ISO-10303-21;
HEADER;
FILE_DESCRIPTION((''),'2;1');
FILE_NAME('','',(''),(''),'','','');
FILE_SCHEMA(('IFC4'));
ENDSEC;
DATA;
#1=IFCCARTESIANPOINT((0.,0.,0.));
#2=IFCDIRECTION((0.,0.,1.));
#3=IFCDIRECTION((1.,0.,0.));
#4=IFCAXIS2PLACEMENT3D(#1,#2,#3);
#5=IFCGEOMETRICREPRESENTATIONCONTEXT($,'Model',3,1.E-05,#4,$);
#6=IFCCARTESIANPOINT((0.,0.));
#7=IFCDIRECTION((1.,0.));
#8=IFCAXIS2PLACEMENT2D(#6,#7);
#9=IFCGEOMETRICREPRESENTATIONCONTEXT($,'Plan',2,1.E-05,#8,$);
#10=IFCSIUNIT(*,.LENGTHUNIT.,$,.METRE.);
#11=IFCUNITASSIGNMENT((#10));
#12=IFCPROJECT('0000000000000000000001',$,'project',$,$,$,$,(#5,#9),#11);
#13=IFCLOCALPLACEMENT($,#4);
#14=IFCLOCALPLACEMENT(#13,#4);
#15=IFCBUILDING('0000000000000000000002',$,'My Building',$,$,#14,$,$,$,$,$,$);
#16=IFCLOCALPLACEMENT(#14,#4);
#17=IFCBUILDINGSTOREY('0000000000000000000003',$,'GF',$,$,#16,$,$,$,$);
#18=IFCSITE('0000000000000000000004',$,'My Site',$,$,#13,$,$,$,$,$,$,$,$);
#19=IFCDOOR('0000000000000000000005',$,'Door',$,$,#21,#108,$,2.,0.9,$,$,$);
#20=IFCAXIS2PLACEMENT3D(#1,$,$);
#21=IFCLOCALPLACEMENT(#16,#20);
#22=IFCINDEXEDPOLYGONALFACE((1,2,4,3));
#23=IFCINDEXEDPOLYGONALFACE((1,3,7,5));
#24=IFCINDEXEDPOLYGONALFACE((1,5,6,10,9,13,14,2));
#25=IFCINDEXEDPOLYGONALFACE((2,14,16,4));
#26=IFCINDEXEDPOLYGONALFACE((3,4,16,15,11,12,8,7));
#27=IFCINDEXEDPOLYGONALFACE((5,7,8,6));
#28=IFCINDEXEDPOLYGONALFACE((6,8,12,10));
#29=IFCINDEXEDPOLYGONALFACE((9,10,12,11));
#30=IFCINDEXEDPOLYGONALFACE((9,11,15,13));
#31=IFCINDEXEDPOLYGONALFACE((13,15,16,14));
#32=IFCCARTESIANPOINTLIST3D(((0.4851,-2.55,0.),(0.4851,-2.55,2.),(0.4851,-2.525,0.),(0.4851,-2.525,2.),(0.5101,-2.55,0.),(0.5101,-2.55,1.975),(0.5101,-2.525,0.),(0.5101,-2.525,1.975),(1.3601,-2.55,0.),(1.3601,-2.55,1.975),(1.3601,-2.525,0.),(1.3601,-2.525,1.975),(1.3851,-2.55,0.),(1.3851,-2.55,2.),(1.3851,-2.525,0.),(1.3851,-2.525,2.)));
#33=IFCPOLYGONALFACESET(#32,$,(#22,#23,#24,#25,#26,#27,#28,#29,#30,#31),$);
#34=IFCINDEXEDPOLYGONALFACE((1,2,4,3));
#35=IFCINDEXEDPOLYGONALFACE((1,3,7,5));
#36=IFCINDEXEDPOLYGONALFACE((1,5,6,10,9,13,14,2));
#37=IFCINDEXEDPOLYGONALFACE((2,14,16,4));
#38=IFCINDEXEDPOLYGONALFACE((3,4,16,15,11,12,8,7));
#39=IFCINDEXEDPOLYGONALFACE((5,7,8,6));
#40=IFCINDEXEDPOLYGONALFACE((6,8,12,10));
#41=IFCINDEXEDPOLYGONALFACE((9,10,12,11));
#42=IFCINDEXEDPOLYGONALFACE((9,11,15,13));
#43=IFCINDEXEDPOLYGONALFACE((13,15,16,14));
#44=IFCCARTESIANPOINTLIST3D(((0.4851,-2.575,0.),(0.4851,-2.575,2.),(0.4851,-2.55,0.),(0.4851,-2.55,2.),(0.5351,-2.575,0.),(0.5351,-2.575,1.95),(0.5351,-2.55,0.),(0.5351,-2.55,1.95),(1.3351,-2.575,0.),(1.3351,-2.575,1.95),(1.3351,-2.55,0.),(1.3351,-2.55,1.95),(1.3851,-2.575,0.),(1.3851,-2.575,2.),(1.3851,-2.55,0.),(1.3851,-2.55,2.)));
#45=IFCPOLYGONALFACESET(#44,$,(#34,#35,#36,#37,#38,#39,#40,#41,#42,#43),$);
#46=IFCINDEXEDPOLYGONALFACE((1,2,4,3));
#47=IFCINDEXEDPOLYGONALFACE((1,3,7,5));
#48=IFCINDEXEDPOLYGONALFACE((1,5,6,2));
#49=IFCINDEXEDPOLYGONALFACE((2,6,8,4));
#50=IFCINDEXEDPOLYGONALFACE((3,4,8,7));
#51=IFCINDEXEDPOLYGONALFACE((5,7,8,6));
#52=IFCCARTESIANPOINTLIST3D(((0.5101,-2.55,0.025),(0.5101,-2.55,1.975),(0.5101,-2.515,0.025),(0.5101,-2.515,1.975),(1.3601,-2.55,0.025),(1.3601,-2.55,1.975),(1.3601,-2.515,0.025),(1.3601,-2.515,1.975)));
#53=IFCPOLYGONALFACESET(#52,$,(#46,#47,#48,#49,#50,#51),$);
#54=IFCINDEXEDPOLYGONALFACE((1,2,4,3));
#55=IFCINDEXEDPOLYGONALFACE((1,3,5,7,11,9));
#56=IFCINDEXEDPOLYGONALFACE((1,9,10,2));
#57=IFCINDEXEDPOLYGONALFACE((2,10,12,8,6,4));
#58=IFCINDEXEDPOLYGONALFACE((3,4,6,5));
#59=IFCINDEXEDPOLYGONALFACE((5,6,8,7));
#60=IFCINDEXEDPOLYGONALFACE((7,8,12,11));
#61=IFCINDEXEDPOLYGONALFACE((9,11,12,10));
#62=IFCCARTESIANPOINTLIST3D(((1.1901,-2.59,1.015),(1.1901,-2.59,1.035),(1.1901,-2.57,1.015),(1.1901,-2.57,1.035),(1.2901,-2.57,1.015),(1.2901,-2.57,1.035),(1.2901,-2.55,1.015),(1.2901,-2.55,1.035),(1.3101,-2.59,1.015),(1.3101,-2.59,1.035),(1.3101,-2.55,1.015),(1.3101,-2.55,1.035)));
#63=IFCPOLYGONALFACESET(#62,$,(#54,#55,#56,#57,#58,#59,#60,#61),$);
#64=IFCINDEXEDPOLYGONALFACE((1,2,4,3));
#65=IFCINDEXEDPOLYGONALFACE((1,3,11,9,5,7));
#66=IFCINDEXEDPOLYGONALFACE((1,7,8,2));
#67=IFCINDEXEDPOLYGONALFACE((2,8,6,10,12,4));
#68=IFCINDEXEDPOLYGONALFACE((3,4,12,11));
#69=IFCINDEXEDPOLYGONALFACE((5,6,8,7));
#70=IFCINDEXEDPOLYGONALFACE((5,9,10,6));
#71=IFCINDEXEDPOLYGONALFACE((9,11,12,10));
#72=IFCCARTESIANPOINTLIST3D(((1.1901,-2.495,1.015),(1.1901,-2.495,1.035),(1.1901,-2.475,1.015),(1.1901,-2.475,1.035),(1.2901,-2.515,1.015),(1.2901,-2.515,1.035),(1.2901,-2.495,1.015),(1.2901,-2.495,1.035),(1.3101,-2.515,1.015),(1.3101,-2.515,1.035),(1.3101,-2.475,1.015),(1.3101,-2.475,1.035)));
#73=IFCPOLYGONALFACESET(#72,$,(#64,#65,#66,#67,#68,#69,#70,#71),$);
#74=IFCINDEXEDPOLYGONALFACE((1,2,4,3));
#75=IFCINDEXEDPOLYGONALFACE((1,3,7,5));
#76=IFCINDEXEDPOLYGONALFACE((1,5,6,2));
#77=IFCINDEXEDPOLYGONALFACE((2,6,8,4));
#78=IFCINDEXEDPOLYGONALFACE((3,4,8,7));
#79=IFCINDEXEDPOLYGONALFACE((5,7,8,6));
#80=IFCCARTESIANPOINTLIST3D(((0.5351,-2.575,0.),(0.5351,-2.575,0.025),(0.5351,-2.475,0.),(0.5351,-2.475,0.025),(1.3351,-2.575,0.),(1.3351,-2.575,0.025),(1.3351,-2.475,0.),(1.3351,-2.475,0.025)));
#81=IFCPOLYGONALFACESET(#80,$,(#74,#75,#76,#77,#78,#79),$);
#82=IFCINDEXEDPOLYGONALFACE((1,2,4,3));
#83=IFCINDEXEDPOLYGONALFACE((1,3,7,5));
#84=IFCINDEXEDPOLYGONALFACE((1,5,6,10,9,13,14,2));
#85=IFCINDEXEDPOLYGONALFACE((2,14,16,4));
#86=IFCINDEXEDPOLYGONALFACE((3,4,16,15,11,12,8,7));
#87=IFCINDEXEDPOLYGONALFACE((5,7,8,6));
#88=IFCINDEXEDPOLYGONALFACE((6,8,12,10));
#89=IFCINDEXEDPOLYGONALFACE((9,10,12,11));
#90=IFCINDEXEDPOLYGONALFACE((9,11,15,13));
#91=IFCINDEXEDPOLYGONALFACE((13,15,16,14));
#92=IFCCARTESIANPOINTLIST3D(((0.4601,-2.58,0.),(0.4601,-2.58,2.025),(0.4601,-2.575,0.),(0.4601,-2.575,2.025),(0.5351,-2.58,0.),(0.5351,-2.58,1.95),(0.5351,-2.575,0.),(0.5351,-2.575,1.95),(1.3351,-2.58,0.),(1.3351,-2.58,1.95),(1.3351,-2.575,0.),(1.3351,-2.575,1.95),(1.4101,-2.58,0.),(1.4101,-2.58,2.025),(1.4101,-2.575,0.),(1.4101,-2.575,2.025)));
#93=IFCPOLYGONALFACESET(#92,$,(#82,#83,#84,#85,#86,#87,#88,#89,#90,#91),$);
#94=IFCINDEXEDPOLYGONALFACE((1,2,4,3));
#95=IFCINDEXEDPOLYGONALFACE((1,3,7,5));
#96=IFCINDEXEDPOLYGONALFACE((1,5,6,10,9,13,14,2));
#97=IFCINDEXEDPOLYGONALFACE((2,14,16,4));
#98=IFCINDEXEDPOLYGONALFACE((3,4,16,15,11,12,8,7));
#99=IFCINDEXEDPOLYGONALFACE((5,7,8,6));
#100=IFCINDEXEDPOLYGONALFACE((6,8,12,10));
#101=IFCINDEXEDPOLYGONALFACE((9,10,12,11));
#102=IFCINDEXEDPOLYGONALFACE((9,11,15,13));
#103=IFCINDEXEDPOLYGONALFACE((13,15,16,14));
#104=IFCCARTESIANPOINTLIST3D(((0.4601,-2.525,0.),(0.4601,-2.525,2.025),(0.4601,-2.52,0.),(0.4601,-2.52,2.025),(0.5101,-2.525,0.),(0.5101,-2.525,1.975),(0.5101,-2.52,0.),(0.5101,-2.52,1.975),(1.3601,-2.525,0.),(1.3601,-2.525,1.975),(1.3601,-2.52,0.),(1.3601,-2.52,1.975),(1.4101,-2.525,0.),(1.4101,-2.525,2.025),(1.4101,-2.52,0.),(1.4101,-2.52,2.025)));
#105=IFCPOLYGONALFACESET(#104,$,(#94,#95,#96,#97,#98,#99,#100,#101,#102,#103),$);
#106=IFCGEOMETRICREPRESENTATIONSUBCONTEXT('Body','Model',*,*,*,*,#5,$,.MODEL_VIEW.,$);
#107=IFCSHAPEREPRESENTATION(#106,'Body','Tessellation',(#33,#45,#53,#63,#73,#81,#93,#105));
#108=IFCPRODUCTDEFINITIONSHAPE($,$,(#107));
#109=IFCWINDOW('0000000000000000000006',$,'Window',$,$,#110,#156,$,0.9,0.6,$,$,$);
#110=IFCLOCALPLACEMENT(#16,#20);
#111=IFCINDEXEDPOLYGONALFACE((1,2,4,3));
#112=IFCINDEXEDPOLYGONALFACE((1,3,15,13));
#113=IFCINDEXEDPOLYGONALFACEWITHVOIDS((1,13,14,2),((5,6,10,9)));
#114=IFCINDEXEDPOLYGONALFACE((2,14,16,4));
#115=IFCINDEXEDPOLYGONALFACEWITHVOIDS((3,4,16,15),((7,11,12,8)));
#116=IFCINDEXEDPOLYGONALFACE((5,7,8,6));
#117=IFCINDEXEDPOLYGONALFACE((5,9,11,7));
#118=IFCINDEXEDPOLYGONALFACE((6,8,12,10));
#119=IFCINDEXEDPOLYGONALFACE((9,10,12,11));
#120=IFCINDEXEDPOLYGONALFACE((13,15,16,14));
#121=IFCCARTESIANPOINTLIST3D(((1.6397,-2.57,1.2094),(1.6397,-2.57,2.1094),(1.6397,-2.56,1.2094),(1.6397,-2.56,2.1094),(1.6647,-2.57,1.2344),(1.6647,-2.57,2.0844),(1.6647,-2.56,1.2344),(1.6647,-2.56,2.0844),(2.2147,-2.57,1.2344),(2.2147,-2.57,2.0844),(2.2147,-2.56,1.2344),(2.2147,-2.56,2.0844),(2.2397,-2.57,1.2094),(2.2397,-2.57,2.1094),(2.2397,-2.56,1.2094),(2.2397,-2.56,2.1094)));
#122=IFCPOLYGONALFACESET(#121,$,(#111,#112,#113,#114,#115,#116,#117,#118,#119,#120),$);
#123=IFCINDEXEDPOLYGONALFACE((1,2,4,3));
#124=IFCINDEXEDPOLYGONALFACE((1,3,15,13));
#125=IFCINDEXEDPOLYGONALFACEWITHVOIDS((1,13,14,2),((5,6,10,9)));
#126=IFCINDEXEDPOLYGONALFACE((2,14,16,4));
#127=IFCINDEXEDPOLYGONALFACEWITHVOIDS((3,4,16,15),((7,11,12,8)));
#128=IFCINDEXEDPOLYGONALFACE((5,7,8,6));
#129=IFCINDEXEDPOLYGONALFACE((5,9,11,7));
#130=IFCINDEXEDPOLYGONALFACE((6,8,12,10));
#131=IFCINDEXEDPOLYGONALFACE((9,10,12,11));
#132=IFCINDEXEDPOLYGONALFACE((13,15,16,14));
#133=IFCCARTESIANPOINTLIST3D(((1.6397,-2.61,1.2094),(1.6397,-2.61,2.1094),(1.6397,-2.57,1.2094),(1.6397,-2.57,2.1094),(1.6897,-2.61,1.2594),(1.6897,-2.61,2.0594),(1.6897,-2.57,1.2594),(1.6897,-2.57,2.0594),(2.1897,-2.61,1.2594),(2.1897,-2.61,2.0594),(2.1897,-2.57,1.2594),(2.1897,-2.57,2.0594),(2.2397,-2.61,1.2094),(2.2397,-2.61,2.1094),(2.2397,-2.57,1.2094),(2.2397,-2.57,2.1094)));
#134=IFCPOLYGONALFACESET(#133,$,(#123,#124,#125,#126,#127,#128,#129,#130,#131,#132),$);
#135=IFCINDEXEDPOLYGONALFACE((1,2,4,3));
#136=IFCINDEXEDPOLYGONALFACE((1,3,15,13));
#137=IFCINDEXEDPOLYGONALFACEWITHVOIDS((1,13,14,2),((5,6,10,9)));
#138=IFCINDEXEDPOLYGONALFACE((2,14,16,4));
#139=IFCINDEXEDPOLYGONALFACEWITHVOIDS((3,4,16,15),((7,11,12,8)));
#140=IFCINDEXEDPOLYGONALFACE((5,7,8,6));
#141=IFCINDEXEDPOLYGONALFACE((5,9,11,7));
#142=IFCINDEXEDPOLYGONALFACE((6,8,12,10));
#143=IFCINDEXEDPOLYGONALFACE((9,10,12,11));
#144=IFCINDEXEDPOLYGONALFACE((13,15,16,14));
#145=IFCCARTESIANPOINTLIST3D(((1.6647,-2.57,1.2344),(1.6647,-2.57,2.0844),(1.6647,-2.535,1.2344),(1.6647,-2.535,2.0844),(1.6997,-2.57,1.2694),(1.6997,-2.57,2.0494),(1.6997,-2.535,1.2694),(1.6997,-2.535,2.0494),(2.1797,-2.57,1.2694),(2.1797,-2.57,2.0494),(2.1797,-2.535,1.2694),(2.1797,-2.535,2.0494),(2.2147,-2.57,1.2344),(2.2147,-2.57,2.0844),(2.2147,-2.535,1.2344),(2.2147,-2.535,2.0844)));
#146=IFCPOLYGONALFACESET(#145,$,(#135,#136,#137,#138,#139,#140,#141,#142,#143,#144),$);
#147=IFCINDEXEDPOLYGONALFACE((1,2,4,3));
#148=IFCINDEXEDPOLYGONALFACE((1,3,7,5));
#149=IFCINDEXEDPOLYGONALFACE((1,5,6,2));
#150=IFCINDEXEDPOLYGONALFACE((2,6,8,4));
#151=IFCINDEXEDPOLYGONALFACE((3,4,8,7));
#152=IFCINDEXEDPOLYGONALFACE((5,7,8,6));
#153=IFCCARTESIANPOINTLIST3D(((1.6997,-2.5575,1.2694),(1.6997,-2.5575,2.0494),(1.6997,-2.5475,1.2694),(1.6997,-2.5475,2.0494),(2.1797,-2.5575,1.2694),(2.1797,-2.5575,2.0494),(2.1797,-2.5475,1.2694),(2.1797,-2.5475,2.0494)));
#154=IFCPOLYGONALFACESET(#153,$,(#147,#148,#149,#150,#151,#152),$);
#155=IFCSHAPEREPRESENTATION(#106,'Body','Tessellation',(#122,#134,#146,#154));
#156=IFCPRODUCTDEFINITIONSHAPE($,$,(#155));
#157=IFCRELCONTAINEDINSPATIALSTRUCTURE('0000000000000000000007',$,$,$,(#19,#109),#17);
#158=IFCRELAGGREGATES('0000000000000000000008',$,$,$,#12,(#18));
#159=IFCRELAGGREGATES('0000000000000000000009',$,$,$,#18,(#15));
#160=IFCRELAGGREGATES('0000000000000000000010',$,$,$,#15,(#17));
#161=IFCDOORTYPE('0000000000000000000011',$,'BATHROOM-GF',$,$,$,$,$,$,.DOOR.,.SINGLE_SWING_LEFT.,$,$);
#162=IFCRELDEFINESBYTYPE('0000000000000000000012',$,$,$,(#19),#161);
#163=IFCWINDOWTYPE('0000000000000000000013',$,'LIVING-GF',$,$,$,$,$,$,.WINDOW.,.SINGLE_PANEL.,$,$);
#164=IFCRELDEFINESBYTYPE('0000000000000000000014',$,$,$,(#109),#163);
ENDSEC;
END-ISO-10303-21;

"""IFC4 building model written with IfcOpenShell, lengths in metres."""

from ifc_helpers import new_model, entity, si_unit, frame, origin_with_axes, origin_2d_with_axis, place, context, subcontext, project, spatial, line, indexed_curve, outline, extrude, shape, source, transform, mapped, type_object, type_shapes, element, save


model = new_model("IFC4")

# Units and contexts
model_context = context("Model", 3, precision=1e-05, world=origin_with_axes())
plan_context = context("Plan", 2, precision=1e-05, world=origin_2d_with_axis())
body_context_1 = subcontext(model_context, "Body", "Model", "MODEL_VIEW")
body_context_2 = subcontext(plan_context, "Body", "Plan", "PLAN_VIEW")
ifc_project = project(units=[si_unit("LENGTHUNIT", "METRE")], contexts=[model_context, plan_context])

# Site, building, storey
site_placement = place(None, origin_with_axes())
site = spatial("IfcSite", under=ifc_project, at=site_placement, Name="My Site")
building_placement = place(site_placement, origin_with_axes())
building = spatial("IfcBuilding", under=site, at=building_placement, Name="My Building")
storey_placement = place(building_placement, origin_with_axes())
storey = spatial("IfcBuildingStorey", under=building, at=storey_placement, Name="GF")

# Door
door_type_1 = type_object("IfcDoorType", Name="BATHROOM-GF", OperationType="SINGLE_SWING_LEFT", PredefinedType="DOOR")
shared_shape_1 = source(origin_with_axes(), body_context_1, "Body", "SweptSolid", [
    extrude(outline(indexed_curve([(0.0, 0.0), (0.0, 2.0), (0.9, 2.0), (0.9, 0.0), (0.875, 0.0), (0.875, 1.975), (0.025, 1.975), (0.025, 0.0)], segments=[line(1, 2, 3, 4, 5, 6, 7, 8, 1)])), frame((0.0, 0.025, 0.0), z_axis=(0.0, -1.0, 0.0), x_axis=(1.0, 0.0, 0.0)), (0.0, 0.0, -1.0), 0.025),
    extrude(outline(indexed_curve([(0.0, 0.0), (0.0, 2.0), (0.9, 2.0), (0.9, 0.0), (0.85, 0.0), (0.85, 1.95), (0.05, 1.95), (0.05, 0.0)], segments=[line(1, 2, 3, 4, 5, 6, 7, 8, 1)])), frame((0.0, 0.0, 0.0), z_axis=(0.0, -1.0, 0.0), x_axis=(1.0, 0.0, 0.0)), (0.0, 0.0, -1.0), 0.025),
    extrude(outline(indexed_curve([(0.0, 0.0), (0.85, 0.0), (0.85, 0.035), (0.0, 0.035)], segments=[line(1, 2, 3, 4, 1)])), frame((0.025, 0.025, 0.025), z_axis=(0.0, 0.0, 1.0), x_axis=(1.0, 0.0, 0.0)), (0.0, 0.0, 1.0), 1.95),
    extrude(outline(indexed_curve([(0.0, 0.0), (0.0, -0.04), (-0.12, -0.04), (-0.12, -0.02), (-0.02, -0.02), (-0.02, 0.0)], segments=[line(1, 2, 3, 4, 5, 6, 1)])), frame((0.825, 0.025, 1.015), z_axis=(0.0, 0.0, 1.0), x_axis=(1.0, 0.0, 0.0)), (0.0, 0.0, 1.0), 0.02),
    extrude(outline(indexed_curve([(0.0, 0.0), (0.0, 0.04), (-0.12, 0.04), (-0.12, 0.02), (-0.02, 0.02), (-0.02, 0.0)], segments=[line(1, 2, 3, 4, 5, 6, 1)])), frame((0.825, 0.06, 1.015), z_axis=(0.0, 0.0, 1.0), x_axis=(1.0, 0.0, 0.0)), (0.0, 0.0, 1.0), 0.02),
    extrude(outline(indexed_curve([(0.0, 0.0), (0.8, 0.0), (0.8, 0.1), (0.0, 0.1)], segments=[line(1, 2, 3, 4, 1)])), frame((0.05, 0.0, 0.0), z_axis=(0.0, 0.0, 1.0), x_axis=(1.0, 0.0, 0.0)), (0.0, 0.0, 1.0), 0.025),
    extrude(outline(indexed_curve([(0.0, 0.0), (0.0, 2.025), (0.95, 2.025), (0.95, 0.0), (0.875, 0.0), (0.875, 1.95), (0.075, 1.95), (0.075, 0.0)], segments=[line(1, 2, 3, 4, 5, 6, 7, 8, 1)])), frame((-0.025, -0.005, 0.0), z_axis=(0.0, -1.0, 0.0), x_axis=(1.0, 0.0, 0.0)), (0.0, 0.0, -1.0), 0.005),
    extrude(outline(indexed_curve([(0.0, 0.0), (0.0, 2.025), (0.95, 2.025), (0.95, 0.0), (0.9, 0.0), (0.9, 1.975), (0.05, 1.975), (0.05, 0.0)], segments=[line(1, 2, 3, 4, 5, 6, 7, 8, 1)])), frame((-0.025, 0.05, 0.0), z_axis=(0.0, -1.0, 0.0), x_axis=(1.0, 0.0, 0.0)), (0.0, 0.0, -1.0), 0.005),
])
shared_shape_2 = source(origin_with_axes(), body_context_2, "Body", "Curve2D", [
    entity("IfcIndexedPolyCurve", entity("IfcCartesianPointList2D", [[0.0, 0.0], [0.0, 0.05], [0.025, 0.05], [0.025, 0.025], [0.05, 0.025], [0.05, 0.0]]), [entity("IfcLineIndex", [1, 2, 3, 4, 5, 6, 1])]),
    entity("IfcIndexedPolyCurve", entity("IfcCartesianPointList2D", [[0.9, 0.0], [0.9, 0.05], [0.875, 0.05], [0.875, 0.025], [0.85, 0.025], [0.85, 0.0]]), [entity("IfcLineIndex", [1, 2, 3, 4, 5, 6, 1])]),
    entity("IfcTrimmedCurve", entity("IfcEllipse", entity("IfcAxis2Placement2D", entity("IfcCartesianPoint", [0.06, 0.05]), entity("IfcDirection", [1.0, 0.0])), 0.815, 0.85), [entity("IfcCartesianPoint", [0.875, 0.05])], [entity("IfcCartesianPoint", [0.06, 0.9])], True, "CARTESIAN"),
    entity("IfcIndexedPolyCurve", entity("IfcCartesianPointList2D", [[0.025, 0.05], [0.06, 0.05], [0.06, 0.9], [0.025, 0.9]]), [entity("IfcLineIndex", [1, 2, 3, 4, 1])]),
])
type_shapes(door_type_1, [shared_shape_1, shared_shape_2])
door_1_placement = place(storey_placement, frame((0.4851, -2.575, 0.0), z_axis=(0.0, 0.0, 1.0), x_axis=(1.0, 0.0, 0.0)))
element("IfcDoor", 1, at=door_1_placement, inside=storey, type_object=door_type_1, Name="Door", OverallHeight=2.0, OverallWidth=0.9, shapes=[
    shape(body_context_1, "Body", "MappedRepresentation", [mapped(shared_shape_1, transform((0.0, 0.0, 0.0), x_axis=(1.0, 0.0, 0.0), y_axis=(0.0, 1.0, 0.0), z_axis=(0.0, 0.0, 1.0), scale=1.0))]),
    shape(body_context_2, "Body", "MappedRepresentation", [mapped(shared_shape_2, transform((0.0, 0.0, 0.0), x_axis=(1.0, 0.0, 0.0), y_axis=(0.0, 1.0, 0.0), z_axis=(0.0, 0.0, 1.0), scale=1.0))]),
])

# Window
window_type_1 = type_object("IfcWindowType", Name="LIVING-GF", PartitioningType="SINGLE_PANEL", PredefinedType="WINDOW")
shared_shape_3 = source(origin_with_axes(), body_context_1, "Body", "SweptSolid", [
    extrude(outline(indexed_curve([(0.0, 0.0), (0.6, 0.0), (0.6, 0.9), (0.0, 0.9)], segments=[line(1, 2, 3, 4, 1)]), holes=[indexed_curve([(0.025, 0.025), (0.575, 0.025), (0.575, 0.875), (0.025, 0.875)], segments=[line(1, 2, 3, 4, 1)])]), frame((0.0, 0.09, 0.0), z_axis=(0.0, -1.0, 0.0), x_axis=(1.0, 0.0, 0.0)), (0.0, 0.0, -1.0), 0.01),
    extrude(outline(indexed_curve([(0.0, 0.0), (0.6, 0.0), (0.6, 0.9), (0.0, 0.9)], segments=[line(1, 2, 3, 4, 1)]), holes=[indexed_curve([(0.05, 0.05), (0.55, 0.05), (0.55, 0.85), (0.05, 0.85)], segments=[line(1, 2, 3, 4, 1)])]), frame((0.0, 0.05, 0.0), z_axis=(0.0, -1.0, 0.0), x_axis=(1.0, 0.0, 0.0)), (0.0, 0.0, -1.0), 0.04),
    extrude(outline(indexed_curve([(0.0, 0.0), (0.55, 0.0), (0.55, 0.85), (0.0, 0.85)], segments=[line(1, 2, 3, 4, 1)]), holes=[indexed_curve([(0.035, 0.035), (0.515, 0.035), (0.515, 0.815), (0.035, 0.815)], segments=[line(1, 2, 3, 4, 1)])]), frame((0.025, 0.09, 0.025), z_axis=(0.0, -1.0, 0.0), x_axis=(1.0, 0.0, 0.0)), (0.0, 0.0, -1.0), 0.035),
    extrude(outline(indexed_curve([(0.035, 0.035), (0.515, 0.035), (0.515, 0.815), (0.035, 0.815)], segments=[line(1, 2, 3, 4, 1)])), frame((0.025, 0.1025, 0.025), z_axis=(0.0, -1.0, 0.0), x_axis=(1.0, 0.0, 0.0)), (0.0, 0.0, -1.0), 0.01),
])
shared_shape_4 = source(origin_with_axes(), body_context_2, "Body", "Curve2D", [
    entity("IfcIndexedPolyCurve", entity("IfcCartesianPointList2D", [[0.05, 0.05], [0.55, 0.05]])),
    entity("IfcIndexedPolyCurve", entity("IfcCartesianPointList2D", [[0.0, 0.1], [0.025, 0.1], [0.025, 0.09], [0.05, 0.09], [0.05, 0.05], [0.0, 0.05]]), [entity("IfcLineIndex", [1, 2, 3, 4, 5, 6, 1])]),
    entity("IfcIndexedPolyCurve", entity("IfcCartesianPointList2D", [[0.6, 0.1], [0.575, 0.1], [0.575, 0.09], [0.55, 0.09], [0.55, 0.05], [0.6, 0.05]]), [entity("IfcLineIndex", [1, 2, 3, 4, 5, 6, 1])]),
    entity("IfcIndexedPolyCurve", entity("IfcCartesianPointList2D", [[0.025, 0.09], [0.06, 0.09], [0.06, 0.125], [0.025, 0.125]]), [entity("IfcLineIndex", [1, 2, 3, 4, 1])]),
    entity("IfcIndexedPolyCurve", entity("IfcCartesianPointList2D", [[0.575, 0.09], [0.54, 0.09], [0.54, 0.125], [0.575, 0.125]]), [entity("IfcLineIndex", [1, 2, 3, 4, 1])]),
    entity("IfcIndexedPolyCurve", entity("IfcCartesianPointList2D", [[0.06, 0.09], [0.54, 0.09]])),
    entity("IfcIndexedPolyCurve", entity("IfcCartesianPointList2D", [[0.06, 0.125], [0.54, 0.125]])),
    entity("IfcIndexedPolyCurve", entity("IfcCartesianPointList2D", [[0.06, 0.1075], [0.54, 0.1075]])),
])
type_shapes(window_type_1, [shared_shape_3, shared_shape_4])
window_1_placement = place(storey_placement, frame((1.6397, -2.66, 1.2094), z_axis=(0.0, 0.0, 1.0), x_axis=(1.0, 0.0, 0.0)))
element("IfcWindow", 2, at=window_1_placement, inside=storey, type_object=window_type_1, Name="Window", OverallHeight=0.9, OverallWidth=0.6, shapes=[
    shape(body_context_1, "Body", "MappedRepresentation", [mapped(shared_shape_3, transform((0.0, 0.0, 0.0), x_axis=(1.0, 0.0, 0.0), y_axis=(0.0, 1.0, 0.0), z_axis=(0.0, 0.0, 1.0), scale=1.0))]),
    shape(body_context_2, "Body", "MappedRepresentation", [mapped(shared_shape_4, transform((0.0, 0.0, 0.0), x_axis=(1.0, 0.0, 0.0), y_axis=(0.0, 1.0, 0.0), z_axis=(0.0, 0.0, 1.0), scale=1.0))]),
])

save(model, "model.ifc")
